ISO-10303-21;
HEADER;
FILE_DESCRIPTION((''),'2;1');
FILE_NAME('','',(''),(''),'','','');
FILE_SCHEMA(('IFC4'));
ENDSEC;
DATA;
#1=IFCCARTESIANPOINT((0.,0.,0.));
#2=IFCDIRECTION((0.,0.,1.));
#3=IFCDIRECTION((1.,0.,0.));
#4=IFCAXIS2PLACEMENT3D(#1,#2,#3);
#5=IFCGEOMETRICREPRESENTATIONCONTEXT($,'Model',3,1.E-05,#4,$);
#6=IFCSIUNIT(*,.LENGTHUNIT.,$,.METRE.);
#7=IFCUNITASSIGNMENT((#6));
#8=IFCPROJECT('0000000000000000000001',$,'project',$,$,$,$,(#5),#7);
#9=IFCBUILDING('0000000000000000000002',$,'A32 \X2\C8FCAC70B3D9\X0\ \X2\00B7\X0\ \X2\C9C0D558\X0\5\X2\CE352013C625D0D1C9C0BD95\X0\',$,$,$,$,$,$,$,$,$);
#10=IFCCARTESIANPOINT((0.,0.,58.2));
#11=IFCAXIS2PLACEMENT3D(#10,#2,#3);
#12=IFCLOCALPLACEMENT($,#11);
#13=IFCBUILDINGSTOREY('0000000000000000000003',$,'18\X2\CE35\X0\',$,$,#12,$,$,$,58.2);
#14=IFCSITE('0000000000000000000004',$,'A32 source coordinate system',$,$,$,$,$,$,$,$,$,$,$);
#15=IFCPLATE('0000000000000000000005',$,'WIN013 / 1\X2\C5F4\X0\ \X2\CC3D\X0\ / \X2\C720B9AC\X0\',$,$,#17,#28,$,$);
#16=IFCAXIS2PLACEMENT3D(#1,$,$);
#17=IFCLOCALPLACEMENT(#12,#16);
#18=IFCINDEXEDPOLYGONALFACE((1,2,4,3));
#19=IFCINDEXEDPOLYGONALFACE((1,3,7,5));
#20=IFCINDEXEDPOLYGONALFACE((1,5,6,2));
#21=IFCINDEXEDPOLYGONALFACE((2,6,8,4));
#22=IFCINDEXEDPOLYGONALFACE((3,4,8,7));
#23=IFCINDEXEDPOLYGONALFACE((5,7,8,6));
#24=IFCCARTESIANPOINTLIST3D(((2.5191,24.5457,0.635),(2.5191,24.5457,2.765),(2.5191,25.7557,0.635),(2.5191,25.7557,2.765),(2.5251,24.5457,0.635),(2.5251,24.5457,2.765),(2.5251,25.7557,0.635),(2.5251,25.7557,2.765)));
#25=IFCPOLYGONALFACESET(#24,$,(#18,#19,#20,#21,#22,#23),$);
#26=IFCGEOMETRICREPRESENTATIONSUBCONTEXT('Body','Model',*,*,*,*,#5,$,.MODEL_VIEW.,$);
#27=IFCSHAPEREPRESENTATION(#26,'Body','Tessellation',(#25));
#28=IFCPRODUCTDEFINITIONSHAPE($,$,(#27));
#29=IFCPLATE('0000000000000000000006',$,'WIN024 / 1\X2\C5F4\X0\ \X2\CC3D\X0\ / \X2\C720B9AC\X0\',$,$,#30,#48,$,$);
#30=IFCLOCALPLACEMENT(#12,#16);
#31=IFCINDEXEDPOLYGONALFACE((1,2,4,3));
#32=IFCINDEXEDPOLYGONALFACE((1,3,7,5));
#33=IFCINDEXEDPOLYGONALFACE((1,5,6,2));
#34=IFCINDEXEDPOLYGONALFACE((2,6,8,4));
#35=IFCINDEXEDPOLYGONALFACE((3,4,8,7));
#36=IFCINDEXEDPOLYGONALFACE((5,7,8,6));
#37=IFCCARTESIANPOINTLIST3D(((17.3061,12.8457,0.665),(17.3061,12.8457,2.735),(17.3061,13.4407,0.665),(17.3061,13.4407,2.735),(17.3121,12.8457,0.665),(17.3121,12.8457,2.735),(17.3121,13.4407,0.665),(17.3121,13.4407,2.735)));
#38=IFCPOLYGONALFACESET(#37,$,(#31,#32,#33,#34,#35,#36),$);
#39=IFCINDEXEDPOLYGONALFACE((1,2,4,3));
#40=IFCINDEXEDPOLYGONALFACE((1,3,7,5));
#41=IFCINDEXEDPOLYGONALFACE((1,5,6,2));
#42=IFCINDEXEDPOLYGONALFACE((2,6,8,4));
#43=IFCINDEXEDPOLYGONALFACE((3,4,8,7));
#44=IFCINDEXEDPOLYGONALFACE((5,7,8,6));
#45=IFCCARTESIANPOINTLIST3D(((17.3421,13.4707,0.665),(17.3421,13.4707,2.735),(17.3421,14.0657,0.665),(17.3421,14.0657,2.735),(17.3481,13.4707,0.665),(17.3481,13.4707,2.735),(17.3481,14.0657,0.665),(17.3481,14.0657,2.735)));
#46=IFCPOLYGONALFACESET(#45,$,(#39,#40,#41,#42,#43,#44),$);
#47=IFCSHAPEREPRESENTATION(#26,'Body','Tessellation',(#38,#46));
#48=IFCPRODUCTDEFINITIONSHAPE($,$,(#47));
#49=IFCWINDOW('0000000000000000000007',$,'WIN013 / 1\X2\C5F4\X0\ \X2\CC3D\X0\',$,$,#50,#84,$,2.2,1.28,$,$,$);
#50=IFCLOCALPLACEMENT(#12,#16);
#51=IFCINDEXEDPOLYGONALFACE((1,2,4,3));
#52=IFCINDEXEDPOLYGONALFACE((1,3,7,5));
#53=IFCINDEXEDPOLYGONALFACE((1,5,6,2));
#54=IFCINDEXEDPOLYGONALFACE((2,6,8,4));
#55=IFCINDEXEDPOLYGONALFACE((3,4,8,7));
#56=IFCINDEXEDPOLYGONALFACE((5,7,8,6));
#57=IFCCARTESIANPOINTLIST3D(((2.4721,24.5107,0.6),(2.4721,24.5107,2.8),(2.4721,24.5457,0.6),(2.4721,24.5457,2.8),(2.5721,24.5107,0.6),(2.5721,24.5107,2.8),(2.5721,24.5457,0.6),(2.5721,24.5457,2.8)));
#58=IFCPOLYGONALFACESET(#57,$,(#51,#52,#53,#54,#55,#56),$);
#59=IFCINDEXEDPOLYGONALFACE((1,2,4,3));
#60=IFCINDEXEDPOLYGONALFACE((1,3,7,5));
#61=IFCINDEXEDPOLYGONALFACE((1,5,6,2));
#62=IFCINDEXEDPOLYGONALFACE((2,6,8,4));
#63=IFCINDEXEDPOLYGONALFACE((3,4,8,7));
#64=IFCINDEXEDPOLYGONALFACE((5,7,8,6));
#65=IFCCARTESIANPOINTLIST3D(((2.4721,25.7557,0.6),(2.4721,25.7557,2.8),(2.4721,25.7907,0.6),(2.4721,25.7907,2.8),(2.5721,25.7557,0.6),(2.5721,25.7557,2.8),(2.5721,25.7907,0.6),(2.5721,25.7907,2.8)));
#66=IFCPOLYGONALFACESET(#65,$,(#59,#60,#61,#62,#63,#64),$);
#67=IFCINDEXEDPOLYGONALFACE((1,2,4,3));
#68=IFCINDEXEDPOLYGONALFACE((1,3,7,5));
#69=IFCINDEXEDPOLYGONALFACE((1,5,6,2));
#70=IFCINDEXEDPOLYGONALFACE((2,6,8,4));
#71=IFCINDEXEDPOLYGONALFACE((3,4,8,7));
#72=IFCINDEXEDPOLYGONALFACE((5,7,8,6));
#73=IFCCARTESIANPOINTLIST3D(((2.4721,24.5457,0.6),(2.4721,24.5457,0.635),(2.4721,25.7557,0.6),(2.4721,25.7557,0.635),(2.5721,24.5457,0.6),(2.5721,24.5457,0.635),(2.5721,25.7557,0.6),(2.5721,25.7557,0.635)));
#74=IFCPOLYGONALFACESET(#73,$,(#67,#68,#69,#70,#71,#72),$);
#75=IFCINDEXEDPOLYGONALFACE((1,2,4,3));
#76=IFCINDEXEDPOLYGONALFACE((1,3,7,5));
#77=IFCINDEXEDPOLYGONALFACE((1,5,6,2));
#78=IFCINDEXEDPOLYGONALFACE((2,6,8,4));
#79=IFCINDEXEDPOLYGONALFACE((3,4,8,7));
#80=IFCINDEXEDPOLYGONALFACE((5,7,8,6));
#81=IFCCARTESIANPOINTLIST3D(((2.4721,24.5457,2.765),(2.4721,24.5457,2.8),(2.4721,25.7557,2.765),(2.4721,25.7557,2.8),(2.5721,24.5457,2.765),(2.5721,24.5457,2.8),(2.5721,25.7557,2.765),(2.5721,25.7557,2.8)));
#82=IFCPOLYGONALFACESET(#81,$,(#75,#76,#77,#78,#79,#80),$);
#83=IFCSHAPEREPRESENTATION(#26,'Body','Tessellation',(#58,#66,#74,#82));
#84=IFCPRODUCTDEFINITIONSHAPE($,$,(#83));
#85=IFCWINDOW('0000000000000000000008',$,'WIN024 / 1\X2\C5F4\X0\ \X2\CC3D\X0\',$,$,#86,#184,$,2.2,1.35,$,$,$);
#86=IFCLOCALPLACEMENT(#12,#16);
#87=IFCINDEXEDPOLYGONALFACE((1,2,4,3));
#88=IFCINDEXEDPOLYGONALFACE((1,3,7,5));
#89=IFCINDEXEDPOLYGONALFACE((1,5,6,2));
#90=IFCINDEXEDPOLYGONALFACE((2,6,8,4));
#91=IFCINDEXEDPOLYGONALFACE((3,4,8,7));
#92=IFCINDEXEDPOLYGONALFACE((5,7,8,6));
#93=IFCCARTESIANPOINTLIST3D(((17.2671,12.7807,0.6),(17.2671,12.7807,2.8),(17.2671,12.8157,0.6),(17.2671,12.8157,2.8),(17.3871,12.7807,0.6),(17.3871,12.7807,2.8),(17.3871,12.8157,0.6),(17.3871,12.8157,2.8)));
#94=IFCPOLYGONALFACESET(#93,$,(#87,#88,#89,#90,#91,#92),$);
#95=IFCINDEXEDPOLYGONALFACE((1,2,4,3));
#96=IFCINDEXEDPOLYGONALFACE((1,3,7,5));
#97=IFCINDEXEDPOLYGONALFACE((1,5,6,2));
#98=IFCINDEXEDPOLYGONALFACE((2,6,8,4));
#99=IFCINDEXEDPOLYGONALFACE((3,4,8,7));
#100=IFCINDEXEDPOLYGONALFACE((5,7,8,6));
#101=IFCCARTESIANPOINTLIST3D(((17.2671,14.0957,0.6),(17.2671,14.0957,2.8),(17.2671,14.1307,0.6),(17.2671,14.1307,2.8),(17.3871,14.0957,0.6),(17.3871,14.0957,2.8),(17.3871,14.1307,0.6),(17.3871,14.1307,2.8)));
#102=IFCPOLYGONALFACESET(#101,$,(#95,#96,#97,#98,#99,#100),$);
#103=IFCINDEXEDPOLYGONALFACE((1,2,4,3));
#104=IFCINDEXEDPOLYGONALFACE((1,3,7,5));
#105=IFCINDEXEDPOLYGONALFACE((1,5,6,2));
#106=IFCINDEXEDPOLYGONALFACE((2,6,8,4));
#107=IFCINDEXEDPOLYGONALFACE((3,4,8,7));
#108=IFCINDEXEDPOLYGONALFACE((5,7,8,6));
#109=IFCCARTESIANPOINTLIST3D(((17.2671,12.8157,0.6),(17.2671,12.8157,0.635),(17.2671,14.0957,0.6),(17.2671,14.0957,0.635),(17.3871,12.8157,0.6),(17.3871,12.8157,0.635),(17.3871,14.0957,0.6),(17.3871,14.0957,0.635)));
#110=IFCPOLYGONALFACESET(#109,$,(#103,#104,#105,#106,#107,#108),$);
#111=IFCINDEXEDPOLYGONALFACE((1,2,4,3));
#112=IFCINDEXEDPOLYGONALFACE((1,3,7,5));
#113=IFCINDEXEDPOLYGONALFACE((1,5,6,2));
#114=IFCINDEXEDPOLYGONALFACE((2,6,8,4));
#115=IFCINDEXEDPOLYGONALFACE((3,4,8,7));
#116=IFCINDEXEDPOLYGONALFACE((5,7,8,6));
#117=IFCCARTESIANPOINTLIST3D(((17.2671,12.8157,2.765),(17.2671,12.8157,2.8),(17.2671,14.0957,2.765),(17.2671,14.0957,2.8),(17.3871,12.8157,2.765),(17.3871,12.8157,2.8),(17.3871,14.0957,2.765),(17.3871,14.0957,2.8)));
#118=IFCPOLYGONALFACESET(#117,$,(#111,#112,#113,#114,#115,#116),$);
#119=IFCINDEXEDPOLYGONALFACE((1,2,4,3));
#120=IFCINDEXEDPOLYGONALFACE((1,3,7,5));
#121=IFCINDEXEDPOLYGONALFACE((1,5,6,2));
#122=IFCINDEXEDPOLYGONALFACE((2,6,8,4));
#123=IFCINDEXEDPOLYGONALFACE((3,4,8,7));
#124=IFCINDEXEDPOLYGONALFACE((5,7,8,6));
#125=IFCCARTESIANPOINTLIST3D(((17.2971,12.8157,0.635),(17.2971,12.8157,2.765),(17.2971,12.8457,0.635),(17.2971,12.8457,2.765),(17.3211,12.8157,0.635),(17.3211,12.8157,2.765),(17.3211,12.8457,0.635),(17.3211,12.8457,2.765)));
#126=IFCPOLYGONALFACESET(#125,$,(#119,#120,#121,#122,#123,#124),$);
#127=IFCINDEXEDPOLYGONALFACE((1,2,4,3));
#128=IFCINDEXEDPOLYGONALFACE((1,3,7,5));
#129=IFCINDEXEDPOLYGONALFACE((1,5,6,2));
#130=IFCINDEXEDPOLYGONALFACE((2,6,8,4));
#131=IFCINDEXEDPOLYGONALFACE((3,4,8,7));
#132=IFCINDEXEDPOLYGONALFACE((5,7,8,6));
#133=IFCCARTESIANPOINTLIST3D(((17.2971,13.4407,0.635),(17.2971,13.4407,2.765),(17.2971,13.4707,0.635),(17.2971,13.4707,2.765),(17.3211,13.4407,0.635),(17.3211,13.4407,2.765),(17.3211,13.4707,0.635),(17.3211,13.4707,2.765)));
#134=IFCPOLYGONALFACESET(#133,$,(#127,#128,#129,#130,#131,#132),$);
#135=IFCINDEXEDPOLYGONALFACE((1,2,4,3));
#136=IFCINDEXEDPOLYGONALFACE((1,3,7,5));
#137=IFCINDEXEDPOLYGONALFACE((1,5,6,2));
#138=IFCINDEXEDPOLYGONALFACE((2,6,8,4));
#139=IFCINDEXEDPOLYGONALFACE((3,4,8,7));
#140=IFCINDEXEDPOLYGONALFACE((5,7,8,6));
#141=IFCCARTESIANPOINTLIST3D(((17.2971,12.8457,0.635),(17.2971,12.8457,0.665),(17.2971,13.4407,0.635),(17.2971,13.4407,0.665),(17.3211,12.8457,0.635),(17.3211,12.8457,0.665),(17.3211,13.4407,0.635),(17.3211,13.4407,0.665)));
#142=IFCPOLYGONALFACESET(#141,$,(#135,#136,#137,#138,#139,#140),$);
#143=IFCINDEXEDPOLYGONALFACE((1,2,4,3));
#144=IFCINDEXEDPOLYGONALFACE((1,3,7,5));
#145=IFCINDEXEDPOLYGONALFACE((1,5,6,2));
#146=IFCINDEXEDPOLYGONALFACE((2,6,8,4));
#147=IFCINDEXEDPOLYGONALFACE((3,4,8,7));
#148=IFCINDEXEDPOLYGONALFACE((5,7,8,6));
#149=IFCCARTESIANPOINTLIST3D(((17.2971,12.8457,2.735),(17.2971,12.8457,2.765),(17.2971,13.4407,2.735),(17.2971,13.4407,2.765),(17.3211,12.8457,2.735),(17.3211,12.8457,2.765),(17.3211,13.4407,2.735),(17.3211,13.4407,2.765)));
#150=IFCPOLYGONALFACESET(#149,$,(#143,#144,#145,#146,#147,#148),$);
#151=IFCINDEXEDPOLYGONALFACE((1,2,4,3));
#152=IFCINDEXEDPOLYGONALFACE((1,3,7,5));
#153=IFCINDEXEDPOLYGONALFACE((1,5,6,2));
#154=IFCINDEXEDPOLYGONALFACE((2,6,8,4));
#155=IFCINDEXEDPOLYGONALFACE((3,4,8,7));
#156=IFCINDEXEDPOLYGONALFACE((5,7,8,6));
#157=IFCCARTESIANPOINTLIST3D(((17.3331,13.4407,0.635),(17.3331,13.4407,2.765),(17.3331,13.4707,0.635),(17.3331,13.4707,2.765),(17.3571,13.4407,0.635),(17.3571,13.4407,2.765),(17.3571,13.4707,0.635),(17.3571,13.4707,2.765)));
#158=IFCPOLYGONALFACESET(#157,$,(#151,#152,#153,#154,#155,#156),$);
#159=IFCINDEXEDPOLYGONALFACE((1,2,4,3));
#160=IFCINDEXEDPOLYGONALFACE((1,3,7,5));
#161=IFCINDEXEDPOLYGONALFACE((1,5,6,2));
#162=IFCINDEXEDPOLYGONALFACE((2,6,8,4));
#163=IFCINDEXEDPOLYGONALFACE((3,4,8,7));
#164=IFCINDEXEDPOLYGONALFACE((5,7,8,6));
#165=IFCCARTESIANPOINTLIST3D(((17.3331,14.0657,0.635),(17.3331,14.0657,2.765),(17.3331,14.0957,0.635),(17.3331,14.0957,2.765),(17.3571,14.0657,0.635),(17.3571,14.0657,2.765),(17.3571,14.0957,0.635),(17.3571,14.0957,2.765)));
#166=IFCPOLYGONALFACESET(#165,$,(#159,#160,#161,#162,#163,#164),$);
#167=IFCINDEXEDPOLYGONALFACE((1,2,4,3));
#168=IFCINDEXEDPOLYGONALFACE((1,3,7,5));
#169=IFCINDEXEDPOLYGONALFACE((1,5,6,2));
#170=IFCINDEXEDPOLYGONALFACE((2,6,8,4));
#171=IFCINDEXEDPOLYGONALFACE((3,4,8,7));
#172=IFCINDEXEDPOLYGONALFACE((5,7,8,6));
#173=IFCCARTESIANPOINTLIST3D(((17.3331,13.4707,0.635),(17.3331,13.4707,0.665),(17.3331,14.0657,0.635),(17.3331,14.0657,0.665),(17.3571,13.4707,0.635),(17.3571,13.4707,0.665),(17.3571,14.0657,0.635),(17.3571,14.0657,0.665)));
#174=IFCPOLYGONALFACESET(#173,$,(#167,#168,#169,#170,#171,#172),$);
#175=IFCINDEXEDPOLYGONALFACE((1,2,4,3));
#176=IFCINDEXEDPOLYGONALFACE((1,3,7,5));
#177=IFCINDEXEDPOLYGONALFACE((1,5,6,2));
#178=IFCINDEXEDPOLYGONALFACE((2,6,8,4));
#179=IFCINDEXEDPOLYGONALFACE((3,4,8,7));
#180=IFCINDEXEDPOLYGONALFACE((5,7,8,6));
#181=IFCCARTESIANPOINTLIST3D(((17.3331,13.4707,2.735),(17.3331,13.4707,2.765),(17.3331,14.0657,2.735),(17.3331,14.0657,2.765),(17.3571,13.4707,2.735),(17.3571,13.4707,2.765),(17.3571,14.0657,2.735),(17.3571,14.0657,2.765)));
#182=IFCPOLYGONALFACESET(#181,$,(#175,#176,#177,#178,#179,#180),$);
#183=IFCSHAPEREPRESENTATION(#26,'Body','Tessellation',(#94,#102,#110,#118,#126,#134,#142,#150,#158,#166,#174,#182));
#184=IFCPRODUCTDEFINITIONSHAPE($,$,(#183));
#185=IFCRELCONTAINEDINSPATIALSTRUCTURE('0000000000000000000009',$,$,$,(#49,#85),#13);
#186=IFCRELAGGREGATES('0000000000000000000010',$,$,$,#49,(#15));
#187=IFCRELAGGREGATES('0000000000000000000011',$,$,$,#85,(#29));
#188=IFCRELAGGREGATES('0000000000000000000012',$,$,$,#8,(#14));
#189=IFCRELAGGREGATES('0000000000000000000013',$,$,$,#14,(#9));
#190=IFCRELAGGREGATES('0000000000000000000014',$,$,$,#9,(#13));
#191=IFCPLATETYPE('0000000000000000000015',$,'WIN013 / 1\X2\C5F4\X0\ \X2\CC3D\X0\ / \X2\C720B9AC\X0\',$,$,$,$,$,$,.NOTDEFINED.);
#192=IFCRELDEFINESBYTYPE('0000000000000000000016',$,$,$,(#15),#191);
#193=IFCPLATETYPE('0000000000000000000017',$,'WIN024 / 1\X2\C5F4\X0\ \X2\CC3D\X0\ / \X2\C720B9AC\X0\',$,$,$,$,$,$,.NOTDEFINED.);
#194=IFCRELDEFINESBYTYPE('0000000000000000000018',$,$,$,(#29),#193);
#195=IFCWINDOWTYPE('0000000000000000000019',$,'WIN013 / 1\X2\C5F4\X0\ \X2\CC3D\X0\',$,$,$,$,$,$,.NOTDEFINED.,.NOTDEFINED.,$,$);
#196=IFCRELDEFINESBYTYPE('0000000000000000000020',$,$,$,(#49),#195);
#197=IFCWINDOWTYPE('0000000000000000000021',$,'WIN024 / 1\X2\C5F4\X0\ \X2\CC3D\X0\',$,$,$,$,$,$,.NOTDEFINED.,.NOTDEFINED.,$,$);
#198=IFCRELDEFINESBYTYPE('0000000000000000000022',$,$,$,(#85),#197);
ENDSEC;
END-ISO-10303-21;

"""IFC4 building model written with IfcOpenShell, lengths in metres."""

from ifc_helpers import new_model, si_unit, frame, origin, origin_with_axes, place, context, subcontext, project, spatial, polyline, outline, extrude, source, transform, mapped, type_object, type_shapes, element, aggregate, save


model = new_model("IFC4")

# Units and contexts
model_context = context("Model", 3, precision=1e-05, world=origin_with_axes())
body_context = subcontext(model_context, "Body", "Model", "MODEL_VIEW")
ifc_project = project(units=[si_unit("LENGTHUNIT", "METRE")], contexts=[model_context])

# Plates
plate_type_1 = type_object("IfcPlateType", Name="WIN013 / 1열 창 / 유리", PredefinedType="NOTDEFINED")
shared_shape_1 = source(origin(), body_context, "Body", "SweptSolid", [
    extrude(outline(polyline([(2.5191, 24.5457), (2.5191, 25.7557), (2.5251, 25.7557), (2.5251, 24.5457), (2.5191, 24.5457)])), frame((0.0, 0.0, 0.635)), (0.0, 0.0, 1.0), 2.13),
])
type_shapes(plate_type_1, [shared_shape_1])
storey_placement = place(None, frame((0.0, 0.0, 58.2), z_axis=(0.0, 0.0, 1.0), x_axis=(1.0, 0.0, 0.0)))
window_1_placement = place(storey_placement, origin_with_axes())
plate_1_placement = place(window_1_placement, origin_with_axes())
plate_1 = element("IfcPlate", 1, at=plate_1_placement, type_object=plate_type_1, Name="WIN013 / 1열 창 / 유리", context=body_context, shape_type="MappedRepresentation", body=[
    mapped(shared_shape_1, transform((0.0, 0.0, 0.0), scale=1.0)),
])
plate_type_2 = type_object("IfcPlateType", Name="WIN024 / 1열 창 / 유리", PredefinedType="NOTDEFINED")
shared_shape_2 = source(origin(), body_context, "Body", "SweptSolid", [
    extrude(outline(polyline([(17.3061, 12.8457), (17.3061, 13.4407), (17.3121, 13.4407), (17.3121, 12.8457), (17.3061, 12.8457)])), frame((0.0, 0.0, 0.665)), (0.0, 0.0, 1.0), 2.07),
    extrude(outline(polyline([(17.3421, 13.4707), (17.3421, 14.0657), (17.3481, 14.0657), (17.3481, 13.4707), (17.3421, 13.4707)])), frame((0.0, 0.0, 0.665)), (0.0, 0.0, 1.0), 2.07),
])
type_shapes(plate_type_2, [shared_shape_2])
window_2_placement = place(storey_placement, origin_with_axes())
plate_2_placement = place(window_2_placement, origin_with_axes())
plate_2 = element("IfcPlate", 2, at=plate_2_placement, type_object=plate_type_2, Name="WIN024 / 1열 창 / 유리", context=body_context, shape_type="MappedRepresentation", body=[
    mapped(shared_shape_2, transform((0.0, 0.0, 0.0), scale=1.0)),
])

# Site, building, storey
site = spatial("IfcSite", under=ifc_project, Name="A32 source coordinate system")
building = spatial("IfcBuilding", under=site, Name="A32 주거동 · 지하5층–옥탑지붕")
storey = spatial("IfcBuildingStorey", under=building, at=storey_placement, Name="18층", Elevation=58.2)

# Windows
window_type_1 = type_object("IfcWindowType", Name="WIN013 / 1열 창", PartitioningType="NOTDEFINED", PredefinedType="NOTDEFINED")
shared_shape_3 = source(origin(), body_context, "Body", "SweptSolid", [
    extrude(outline(polyline([(2.4721, 24.5107), (2.4721, 24.5457), (2.5721, 24.5457), (2.5721, 24.5107), (2.4721, 24.5107)])), frame((0.0, 0.0, 0.6)), (0.0, 0.0, 1.0), 2.2),
    extrude(outline(polyline([(2.4721, 25.7557), (2.4721, 25.7907), (2.5721, 25.7907), (2.5721, 25.7557), (2.4721, 25.7557)])), frame((0.0, 0.0, 0.6)), (0.0, 0.0, 1.0), 2.2),
    extrude(outline(polyline([(2.4721, 24.5457), (2.4721, 25.7557), (2.5721, 25.7557), (2.5721, 24.5457), (2.4721, 24.5457)])), frame((0.0, 0.0, 0.6)), (0.0, 0.0, 1.0), 0.035),
    extrude(outline(polyline([(2.4721, 24.5457), (2.4721, 25.7557), (2.5721, 25.7557), (2.5721, 24.5457), (2.4721, 24.5457)])), frame((0.0, 0.0, 2.765)), (0.0, 0.0, 1.0), 0.035),
])
type_shapes(window_type_1, [shared_shape_3])
window_1 = element("IfcWindow", 3, at=window_1_placement, inside=storey, type_object=window_type_1, Name="WIN013 / 1열 창", OverallHeight=2.2, OverallWidth=1.28, context=body_context, shape_type="MappedRepresentation", body=[
    mapped(shared_shape_3, transform((0.0, 0.0, 0.0), scale=1.0)),
])
aggregate(window_1, [plate_1])
window_type_2 = type_object("IfcWindowType", Name="WIN024 / 1열 창", PartitioningType="NOTDEFINED", PredefinedType="NOTDEFINED")
shared_shape_4 = source(origin(), body_context, "Body", "SweptSolid", [
    extrude(outline(polyline([(17.2671, 12.7807), (17.2671, 12.8157), (17.3871, 12.8157), (17.3871, 12.7807), (17.2671, 12.7807)])), frame((0.0, 0.0, 0.6)), (0.0, 0.0, 1.0), 2.2),
    extrude(outline(polyline([(17.2671, 14.0957), (17.2671, 14.1307), (17.3871, 14.1307), (17.3871, 14.0957), (17.2671, 14.0957)])), frame((0.0, 0.0, 0.6)), (0.0, 0.0, 1.0), 2.2),
    extrude(outline(polyline([(17.2671, 12.8157), (17.2671, 14.0957), (17.3871, 14.0957), (17.3871, 12.8157), (17.2671, 12.8157)])), frame((0.0, 0.0, 0.6)), (0.0, 0.0, 1.0), 0.035),
    extrude(outline(polyline([(17.2671, 12.8157), (17.2671, 14.0957), (17.3871, 14.0957), (17.3871, 12.8157), (17.2671, 12.8157)])), frame((0.0, 0.0, 2.765)), (0.0, 0.0, 1.0), 0.035),
    extrude(outline(polyline([(17.2971, 12.8157), (17.2971, 12.8457), (17.3211, 12.8457), (17.3211, 12.8157), (17.2971, 12.8157)])), frame((0.0, 0.0, 0.635)), (0.0, 0.0, 1.0), 2.13),
    extrude(outline(polyline([(17.2971, 13.4407), (17.2971, 13.4707), (17.3211, 13.4707), (17.3211, 13.4407), (17.2971, 13.4407)])), frame((0.0, 0.0, 0.635)), (0.0, 0.0, 1.0), 2.13),
    extrude(outline(polyline([(17.2971, 12.8457), (17.2971, 13.4407), (17.3211, 13.4407), (17.3211, 12.8457), (17.2971, 12.8457)])), frame((0.0, 0.0, 0.635)), (0.0, 0.0, 1.0), 0.03),
    extrude(outline(polyline([(17.2971, 12.8457), (17.2971, 13.4407), (17.3211, 13.4407), (17.3211, 12.8457), (17.2971, 12.8457)])), frame((0.0, 0.0, 2.735)), (0.0, 0.0, 1.0), 0.03),
    extrude(outline(polyline([(17.3331, 13.4407), (17.3331, 13.4707), (17.3571, 13.4707), (17.3571, 13.4407), (17.3331, 13.4407)])), frame((0.0, 0.0, 0.635)), (0.0, 0.0, 1.0), 2.13),
    extrude(outline(polyline([(17.3331, 14.0657), (17.3331, 14.0957), (17.3571, 14.0957), (17.3571, 14.0657), (17.3331, 14.0657)])), frame((0.0, 0.0, 0.635)), (0.0, 0.0, 1.0), 2.13),
    extrude(outline(polyline([(17.3331, 13.4707), (17.3331, 14.0657), (17.3571, 14.0657), (17.3571, 13.4707), (17.3331, 13.4707)])), frame((0.0, 0.0, 0.635)), (0.0, 0.0, 1.0), 0.03),
    extrude(outline(polyline([(17.3331, 13.4707), (17.3331, 14.0657), (17.3571, 14.0657), (17.3571, 13.4707), (17.3331, 13.4707)])), frame((0.0, 0.0, 2.735)), (0.0, 0.0, 1.0), 0.03),
])
type_shapes(window_type_2, [shared_shape_4])
window_2 = element("IfcWindow", 4, at=window_2_placement, inside=storey, type_object=window_type_2, Name="WIN024 / 1열 창", OverallHeight=2.2, OverallWidth=1.35, context=body_context, shape_type="MappedRepresentation", body=[
    mapped(shared_shape_4, transform((0.0, 0.0, 0.0), scale=1.0)),
])
aggregate(window_2, [plate_2])

save(model, "model.ifc")
